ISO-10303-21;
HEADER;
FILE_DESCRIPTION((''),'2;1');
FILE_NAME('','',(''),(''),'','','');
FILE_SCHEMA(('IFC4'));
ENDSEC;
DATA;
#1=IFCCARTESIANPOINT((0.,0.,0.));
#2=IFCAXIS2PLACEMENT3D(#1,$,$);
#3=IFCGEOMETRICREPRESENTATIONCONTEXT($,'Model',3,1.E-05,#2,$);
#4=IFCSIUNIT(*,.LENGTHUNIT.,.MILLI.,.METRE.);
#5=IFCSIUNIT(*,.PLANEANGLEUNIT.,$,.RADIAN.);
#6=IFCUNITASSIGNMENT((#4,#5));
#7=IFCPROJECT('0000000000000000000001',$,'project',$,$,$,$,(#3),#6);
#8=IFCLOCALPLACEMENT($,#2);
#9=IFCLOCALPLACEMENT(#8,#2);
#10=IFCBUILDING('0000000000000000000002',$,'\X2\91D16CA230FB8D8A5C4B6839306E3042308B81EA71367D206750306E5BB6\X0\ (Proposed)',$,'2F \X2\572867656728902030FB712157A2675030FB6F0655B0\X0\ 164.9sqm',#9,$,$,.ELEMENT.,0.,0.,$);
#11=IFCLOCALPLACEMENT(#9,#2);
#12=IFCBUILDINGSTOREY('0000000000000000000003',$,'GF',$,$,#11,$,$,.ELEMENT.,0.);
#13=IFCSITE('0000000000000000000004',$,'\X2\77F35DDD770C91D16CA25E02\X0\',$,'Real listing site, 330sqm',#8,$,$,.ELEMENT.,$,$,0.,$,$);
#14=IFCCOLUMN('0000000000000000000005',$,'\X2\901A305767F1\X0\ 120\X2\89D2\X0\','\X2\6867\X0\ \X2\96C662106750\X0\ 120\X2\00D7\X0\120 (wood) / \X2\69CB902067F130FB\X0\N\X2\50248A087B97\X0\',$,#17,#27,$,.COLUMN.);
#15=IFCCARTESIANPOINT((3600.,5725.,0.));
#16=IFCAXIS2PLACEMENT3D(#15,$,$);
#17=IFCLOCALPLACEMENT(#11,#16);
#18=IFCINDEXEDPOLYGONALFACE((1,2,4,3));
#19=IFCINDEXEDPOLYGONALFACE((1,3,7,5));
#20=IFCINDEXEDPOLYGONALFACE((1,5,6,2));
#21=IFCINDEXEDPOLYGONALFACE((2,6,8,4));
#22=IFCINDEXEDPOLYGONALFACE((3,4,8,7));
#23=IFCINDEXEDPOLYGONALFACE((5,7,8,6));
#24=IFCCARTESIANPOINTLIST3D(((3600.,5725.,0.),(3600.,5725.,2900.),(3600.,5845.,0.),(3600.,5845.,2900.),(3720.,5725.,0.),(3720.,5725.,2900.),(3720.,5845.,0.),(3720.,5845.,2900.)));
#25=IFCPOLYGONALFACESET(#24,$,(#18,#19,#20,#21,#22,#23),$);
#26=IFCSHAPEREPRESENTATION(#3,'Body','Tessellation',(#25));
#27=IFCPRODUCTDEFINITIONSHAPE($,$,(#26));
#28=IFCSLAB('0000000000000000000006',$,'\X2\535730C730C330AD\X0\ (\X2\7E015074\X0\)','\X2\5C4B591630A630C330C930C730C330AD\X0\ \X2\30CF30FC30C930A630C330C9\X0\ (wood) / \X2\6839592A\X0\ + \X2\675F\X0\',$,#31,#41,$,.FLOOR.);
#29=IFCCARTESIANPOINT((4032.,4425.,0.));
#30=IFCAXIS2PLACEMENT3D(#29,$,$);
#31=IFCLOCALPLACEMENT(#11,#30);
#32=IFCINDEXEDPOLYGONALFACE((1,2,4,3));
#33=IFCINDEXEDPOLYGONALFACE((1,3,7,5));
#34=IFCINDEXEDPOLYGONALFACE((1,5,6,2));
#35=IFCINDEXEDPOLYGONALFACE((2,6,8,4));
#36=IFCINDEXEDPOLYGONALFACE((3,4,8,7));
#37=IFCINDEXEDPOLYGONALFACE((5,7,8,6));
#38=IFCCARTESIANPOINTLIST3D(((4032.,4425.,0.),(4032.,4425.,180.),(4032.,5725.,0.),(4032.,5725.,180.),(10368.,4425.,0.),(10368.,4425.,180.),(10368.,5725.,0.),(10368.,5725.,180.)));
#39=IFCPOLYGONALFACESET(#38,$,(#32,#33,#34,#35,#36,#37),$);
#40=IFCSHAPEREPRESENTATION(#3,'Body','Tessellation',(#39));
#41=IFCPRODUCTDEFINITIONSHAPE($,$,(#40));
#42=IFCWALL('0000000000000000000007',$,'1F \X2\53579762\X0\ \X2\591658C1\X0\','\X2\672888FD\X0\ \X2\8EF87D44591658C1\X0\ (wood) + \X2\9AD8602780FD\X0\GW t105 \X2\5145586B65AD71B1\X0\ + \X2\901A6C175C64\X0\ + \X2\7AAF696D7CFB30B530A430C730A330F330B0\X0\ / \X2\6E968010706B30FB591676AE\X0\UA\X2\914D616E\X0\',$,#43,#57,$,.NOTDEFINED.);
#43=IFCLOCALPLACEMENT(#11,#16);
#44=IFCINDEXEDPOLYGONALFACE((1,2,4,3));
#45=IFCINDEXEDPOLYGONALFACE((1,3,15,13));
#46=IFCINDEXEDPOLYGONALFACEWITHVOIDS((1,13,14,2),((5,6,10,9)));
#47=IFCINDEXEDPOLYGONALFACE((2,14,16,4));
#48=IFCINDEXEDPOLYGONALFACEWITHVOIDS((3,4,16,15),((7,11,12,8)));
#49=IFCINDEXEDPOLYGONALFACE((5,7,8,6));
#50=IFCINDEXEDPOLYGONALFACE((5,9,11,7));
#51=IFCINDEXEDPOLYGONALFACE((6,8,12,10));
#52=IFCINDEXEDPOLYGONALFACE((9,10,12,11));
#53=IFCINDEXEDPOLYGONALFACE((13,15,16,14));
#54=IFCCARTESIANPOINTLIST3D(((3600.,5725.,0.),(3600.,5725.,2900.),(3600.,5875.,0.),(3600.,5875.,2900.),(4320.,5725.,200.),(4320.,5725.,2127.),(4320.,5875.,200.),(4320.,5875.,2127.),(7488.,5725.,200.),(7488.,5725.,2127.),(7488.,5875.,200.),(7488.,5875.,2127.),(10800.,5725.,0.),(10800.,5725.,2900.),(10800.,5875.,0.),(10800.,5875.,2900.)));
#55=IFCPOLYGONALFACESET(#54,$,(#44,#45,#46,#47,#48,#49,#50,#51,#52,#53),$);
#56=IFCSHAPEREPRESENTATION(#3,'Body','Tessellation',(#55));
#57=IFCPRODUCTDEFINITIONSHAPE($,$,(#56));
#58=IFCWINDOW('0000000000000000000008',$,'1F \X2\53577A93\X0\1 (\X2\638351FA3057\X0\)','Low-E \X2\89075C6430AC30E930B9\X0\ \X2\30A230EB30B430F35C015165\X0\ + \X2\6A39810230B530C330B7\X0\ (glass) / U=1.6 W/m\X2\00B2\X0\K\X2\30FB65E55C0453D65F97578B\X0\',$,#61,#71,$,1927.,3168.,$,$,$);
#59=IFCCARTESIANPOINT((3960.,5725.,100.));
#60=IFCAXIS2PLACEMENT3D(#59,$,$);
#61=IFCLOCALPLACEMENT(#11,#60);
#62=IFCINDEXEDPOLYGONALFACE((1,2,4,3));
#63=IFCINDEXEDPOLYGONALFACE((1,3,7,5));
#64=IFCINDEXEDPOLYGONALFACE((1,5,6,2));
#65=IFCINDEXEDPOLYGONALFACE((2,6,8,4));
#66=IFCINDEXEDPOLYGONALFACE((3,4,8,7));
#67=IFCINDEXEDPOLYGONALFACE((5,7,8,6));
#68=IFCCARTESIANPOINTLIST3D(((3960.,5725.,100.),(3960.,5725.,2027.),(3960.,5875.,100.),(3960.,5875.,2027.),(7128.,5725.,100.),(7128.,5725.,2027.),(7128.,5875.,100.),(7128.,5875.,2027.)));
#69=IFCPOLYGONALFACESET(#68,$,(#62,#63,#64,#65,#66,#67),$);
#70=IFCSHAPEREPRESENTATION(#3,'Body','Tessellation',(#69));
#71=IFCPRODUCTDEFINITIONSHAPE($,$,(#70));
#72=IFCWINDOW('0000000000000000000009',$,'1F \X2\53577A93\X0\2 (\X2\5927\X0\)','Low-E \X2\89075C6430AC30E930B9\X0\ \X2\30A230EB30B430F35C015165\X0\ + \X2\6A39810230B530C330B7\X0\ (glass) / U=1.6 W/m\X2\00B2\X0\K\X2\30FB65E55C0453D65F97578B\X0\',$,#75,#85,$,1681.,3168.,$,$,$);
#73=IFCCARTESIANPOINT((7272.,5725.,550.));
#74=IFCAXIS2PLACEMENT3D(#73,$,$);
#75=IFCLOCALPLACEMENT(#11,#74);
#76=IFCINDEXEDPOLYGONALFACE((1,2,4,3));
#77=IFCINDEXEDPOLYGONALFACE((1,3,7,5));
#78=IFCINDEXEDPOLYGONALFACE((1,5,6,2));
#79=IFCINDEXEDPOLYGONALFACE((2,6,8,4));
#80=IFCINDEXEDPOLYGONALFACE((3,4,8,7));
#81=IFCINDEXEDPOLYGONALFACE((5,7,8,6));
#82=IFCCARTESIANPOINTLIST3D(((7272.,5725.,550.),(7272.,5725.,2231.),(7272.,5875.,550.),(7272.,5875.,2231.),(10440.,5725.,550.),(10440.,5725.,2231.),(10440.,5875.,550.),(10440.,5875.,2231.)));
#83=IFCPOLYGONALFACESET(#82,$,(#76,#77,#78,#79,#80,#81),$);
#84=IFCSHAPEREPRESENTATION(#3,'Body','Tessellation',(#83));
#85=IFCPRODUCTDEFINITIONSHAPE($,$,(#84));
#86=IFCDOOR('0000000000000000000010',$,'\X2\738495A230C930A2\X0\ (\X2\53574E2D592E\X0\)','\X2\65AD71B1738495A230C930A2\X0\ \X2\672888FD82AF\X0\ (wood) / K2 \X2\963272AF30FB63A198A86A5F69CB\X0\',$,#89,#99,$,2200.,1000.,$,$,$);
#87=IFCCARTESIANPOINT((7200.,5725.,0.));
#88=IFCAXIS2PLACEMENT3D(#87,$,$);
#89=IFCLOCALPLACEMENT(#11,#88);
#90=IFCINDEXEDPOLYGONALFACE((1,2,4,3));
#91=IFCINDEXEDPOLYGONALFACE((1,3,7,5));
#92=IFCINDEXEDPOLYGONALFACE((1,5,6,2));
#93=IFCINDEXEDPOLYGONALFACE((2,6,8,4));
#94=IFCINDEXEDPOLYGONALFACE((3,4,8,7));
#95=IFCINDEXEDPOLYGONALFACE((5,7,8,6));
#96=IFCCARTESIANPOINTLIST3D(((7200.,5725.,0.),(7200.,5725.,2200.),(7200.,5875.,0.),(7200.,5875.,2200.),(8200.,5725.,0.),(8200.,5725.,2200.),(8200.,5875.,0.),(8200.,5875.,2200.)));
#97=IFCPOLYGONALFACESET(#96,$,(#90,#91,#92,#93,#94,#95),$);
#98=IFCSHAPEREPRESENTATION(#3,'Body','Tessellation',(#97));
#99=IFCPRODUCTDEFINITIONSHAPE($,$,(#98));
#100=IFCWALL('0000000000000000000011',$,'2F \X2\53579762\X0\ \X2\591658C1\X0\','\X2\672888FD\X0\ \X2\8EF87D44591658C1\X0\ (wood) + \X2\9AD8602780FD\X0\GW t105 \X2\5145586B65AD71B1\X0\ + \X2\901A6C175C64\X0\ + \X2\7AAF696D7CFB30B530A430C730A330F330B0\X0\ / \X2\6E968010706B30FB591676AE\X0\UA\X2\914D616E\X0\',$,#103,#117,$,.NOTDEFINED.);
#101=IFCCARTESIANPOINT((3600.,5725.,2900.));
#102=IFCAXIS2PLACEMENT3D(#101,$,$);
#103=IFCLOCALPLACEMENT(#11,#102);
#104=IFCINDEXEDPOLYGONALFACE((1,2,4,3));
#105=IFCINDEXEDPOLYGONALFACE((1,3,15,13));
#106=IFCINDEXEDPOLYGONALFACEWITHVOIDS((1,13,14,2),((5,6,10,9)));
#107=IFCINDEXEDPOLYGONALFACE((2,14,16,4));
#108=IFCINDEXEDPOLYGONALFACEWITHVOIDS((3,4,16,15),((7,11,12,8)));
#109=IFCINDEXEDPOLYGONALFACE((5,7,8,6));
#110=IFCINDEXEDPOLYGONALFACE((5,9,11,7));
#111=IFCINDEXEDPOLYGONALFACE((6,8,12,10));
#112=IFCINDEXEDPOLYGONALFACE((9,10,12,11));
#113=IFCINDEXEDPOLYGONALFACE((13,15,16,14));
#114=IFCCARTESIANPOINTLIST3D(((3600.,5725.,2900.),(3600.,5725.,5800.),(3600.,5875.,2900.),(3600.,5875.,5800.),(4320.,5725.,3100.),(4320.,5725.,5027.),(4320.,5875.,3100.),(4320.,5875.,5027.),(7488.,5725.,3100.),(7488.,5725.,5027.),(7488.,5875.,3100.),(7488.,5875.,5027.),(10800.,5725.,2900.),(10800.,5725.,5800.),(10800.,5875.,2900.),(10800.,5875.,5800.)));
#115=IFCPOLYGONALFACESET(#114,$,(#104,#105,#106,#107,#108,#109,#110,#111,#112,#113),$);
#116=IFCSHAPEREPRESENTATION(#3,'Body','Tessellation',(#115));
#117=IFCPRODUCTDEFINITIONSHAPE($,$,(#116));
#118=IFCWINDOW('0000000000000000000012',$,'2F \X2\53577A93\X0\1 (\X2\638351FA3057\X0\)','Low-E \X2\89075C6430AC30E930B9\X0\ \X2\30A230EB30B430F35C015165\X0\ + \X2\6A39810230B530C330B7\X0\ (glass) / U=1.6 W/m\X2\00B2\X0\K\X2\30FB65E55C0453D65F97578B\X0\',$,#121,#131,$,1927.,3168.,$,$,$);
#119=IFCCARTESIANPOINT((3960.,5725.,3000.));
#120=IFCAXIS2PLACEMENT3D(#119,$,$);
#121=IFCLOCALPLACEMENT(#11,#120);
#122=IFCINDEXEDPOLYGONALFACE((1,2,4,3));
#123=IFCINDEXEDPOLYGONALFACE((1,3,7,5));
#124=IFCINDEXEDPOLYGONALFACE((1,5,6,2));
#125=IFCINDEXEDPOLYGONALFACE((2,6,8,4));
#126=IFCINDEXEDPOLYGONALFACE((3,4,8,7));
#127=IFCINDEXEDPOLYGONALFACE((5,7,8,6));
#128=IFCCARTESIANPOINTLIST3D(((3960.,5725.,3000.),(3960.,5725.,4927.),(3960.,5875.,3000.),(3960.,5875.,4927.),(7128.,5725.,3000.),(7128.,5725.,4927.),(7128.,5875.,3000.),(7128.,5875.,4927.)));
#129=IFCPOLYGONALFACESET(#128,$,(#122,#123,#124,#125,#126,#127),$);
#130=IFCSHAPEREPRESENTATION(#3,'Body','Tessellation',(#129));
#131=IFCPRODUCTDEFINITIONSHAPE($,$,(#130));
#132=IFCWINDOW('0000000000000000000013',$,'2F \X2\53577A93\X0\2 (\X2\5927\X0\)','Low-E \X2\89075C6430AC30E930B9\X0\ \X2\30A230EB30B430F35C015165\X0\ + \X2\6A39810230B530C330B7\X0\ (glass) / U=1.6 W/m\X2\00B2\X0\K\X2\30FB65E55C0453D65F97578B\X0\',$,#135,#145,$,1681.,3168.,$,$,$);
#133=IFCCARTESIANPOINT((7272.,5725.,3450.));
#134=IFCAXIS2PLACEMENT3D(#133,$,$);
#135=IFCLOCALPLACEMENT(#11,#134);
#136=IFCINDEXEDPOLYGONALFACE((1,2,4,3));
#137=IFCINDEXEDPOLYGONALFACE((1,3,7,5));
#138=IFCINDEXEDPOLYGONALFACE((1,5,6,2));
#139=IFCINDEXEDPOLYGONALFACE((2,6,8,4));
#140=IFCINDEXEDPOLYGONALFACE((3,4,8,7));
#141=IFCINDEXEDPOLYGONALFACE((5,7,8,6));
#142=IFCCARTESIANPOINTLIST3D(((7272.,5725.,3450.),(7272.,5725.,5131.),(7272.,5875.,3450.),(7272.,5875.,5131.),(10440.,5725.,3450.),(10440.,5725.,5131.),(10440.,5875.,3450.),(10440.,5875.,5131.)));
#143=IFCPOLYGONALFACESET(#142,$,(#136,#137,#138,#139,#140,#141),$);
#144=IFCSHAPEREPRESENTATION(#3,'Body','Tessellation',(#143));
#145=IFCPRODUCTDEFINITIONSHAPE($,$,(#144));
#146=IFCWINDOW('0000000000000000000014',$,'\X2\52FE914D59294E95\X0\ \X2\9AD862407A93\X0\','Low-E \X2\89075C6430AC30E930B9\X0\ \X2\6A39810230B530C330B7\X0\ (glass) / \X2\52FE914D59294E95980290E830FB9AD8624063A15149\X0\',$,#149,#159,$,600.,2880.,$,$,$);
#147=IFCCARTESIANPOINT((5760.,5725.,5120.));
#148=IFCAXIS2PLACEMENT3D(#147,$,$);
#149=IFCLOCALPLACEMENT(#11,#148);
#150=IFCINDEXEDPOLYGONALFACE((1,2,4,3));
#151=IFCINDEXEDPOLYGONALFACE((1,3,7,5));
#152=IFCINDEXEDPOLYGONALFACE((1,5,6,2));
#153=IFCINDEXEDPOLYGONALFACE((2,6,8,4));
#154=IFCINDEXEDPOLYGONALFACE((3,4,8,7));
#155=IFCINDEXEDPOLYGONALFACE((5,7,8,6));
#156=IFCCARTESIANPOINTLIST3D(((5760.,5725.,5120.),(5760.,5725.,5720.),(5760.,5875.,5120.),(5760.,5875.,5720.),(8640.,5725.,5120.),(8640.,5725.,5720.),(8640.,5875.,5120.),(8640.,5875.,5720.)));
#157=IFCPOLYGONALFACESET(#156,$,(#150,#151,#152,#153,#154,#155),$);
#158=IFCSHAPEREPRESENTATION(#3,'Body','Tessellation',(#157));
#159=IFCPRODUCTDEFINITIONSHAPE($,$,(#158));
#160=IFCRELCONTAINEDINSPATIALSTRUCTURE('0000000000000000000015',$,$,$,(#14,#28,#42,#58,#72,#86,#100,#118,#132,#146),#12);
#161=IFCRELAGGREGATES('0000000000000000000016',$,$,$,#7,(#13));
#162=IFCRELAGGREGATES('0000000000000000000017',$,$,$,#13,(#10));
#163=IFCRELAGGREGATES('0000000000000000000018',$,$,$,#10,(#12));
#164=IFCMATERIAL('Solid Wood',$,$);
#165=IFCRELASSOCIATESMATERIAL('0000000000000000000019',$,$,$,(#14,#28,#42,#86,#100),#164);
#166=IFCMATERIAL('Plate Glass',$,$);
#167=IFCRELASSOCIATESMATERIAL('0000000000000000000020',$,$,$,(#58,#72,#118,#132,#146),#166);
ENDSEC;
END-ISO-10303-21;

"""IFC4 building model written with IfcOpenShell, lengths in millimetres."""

from ifc_helpers import new_model, si_unit, frame, frame_2d, origin, place, context, project, spatial, rectangle, extrude, material, element, fill, save


model = new_model("IFC4")

# Units and contexts
model_context = context("Model", 3, precision=1e-05, world=origin())
ifc_project = project(units=[si_unit("LENGTHUNIT", "METRE", prefix="MILLI"), si_unit("PLANEANGLEUNIT", "RADIAN")], contexts=[model_context])

# Site, building, storey
site_placement = place(None, origin())
site = spatial("IfcSite", under=ifc_project, at=site_placement, Name="石川県金沢市", ObjectType="Real listing site, 330sqm", CompositionType="ELEMENT", RefElevation=0.0)
building_placement = place(site_placement, origin())
building = spatial("IfcBuilding", under=site, at=building_placement, Name="金沢・越屋根のある自然素材の家 (Proposed)", ObjectType="2F 在来木造・無垢材・漆喰 164.9sqm", CompositionType="ELEMENT", ElevationOfRefHeight=0.0, ElevationOfTerrain=0.0)
storey_placement = place(building_placement, origin())
storey = spatial("IfcBuildingStorey", under=building, at=storey_placement, Name="GF", CompositionType="ELEMENT", Elevation=0.0)

# Column
ifc_material_1 = material(Name="Solid Wood")
column_placement = place(storey_placement, frame((3600.0, 5725.0, 0.0)))
element("IfcColumn", 1, at=column_placement, inside=storey, material=ifc_material_1, Name="通し柱 120角", Description="桧 集成材 120×120 (wood) / 構造柱・N値計算", PredefinedType="COLUMN", context=model_context, shape_type="SweptSolid", body=[
    extrude(rectangle(XDim=120.0, YDim=120.0, at=frame_2d((60.0, 60.0))), frame((3600.0, 5725.0, 0.0)), (0.0, 0.0, 1.0), 2900.0),
])

# Slab
slab_1_placement = place(storey_placement, frame((4032.0, 4425.0, 0.0)))
element("IfcSlab", 2, at=slab_1_placement, inside=storey, material=ifc_material_1, Name="南デッキ (縁側)", Description="屋外ウッドデッキ ハードウッド (wood) / 根太 + 束", PredefinedType="FLOOR", context=model_context, shape_type="SweptSolid", body=[
    extrude(rectangle(XDim=6336.0, YDim=1300.0, at=frame_2d((3168.0, 650.0))), frame((4032.0, 4425.0, 0.0)), (0.0, 0.0, 1.0), 180.0),
])

# Wall, openings, windows, door
wall_1_placement = place(storey_placement, frame((3600.0, 5725.0, 0.0)))
wall_1 = element("IfcWall", 3, at=wall_1_placement, inside=storey, material=ifc_material_1, Name="1F 南面 外壁", Description="木製 軸組外壁 (wood) + 高性能GW t105 充填断熱 + 通気層 + 窯業系サイディング / 準耐火・外皮UA配慮", PredefinedType="NOTDEFINED", context=model_context, shape_type="SweptSolid", body=[
    extrude(rectangle(XDim=7200.0, YDim=150.0, at=frame_2d((3600.0, 75.0))), frame((3600.0, 5725.0, 0.0)), (0.0, 0.0, 1.0), 2900.0),
])
opening_1_placement = place(storey_placement, frame((3960.0, 5725.0, 100.0)))
opening_1 = element("IfcOpeningElement", 4, at=opening_1_placement, cuts=wall_1, PredefinedType="NOTDEFINED", context=model_context, shape_type="SweptSolid", body=[
    extrude(rectangle(XDim=3168.0, YDim=150.0, at=frame_2d((1584.0, 75.0))), frame((3960.0, 5725.0, 100.0)), (0.0, 0.0, 1.0), 1927.0),
])
opening_2_placement = place(storey_placement, frame((7272.0, 5725.0, 550.0)))
opening_2 = element("IfcOpeningElement", 5, at=opening_2_placement, cuts=wall_1, PredefinedType="NOTDEFINED", context=model_context, shape_type="SweptSolid", body=[
    extrude(rectangle(XDim=3168.0, YDim=150.0, at=frame_2d((1584.0, 75.0))), frame((7272.0, 5725.0, 550.0)), (0.0, 0.0, 1.0), 1681.0),
])
opening_3_placement = place(storey_placement, frame((7200.0, 5725.0, 0.0)))
opening_3 = element("IfcOpeningElement", 6, at=opening_3_placement, cuts=wall_1, PredefinedType="NOTDEFINED", context=model_context, shape_type="SweptSolid", body=[
    extrude(rectangle(XDim=1000.0, YDim=150.0, at=frame_2d((500.0, 75.0))), frame((7200.0, 5725.0, 0.0)), (0.0, 0.0, 1.0), 2200.0),
])
ifc_material_2 = material(Name="Plate Glass")
window_1_placement = place(storey_placement, frame((3960.0, 5725.0, 100.0)))
window_1 = element("IfcWindow", 7, at=window_1_placement, inside=storey, material=ifc_material_2, Name="1F 南窓1 (掃出し)", Description="Low-E 複層ガラス アルゴン封入 + 樹脂サッシ (glass) / U=1.6 W/m²K・日射取得型", OverallHeight=1927.0, OverallWidth=3168.0, context=model_context, shape_type="SweptSolid", body=[
    extrude(rectangle(XDim=3168.0, YDim=150.0, at=frame_2d((1584.0, 75.0))), frame((3960.0, 5725.0, 100.0)), (0.0, 0.0, 1.0), 1927.0),
])
fill(opening_1, window_1)
window_2_placement = place(storey_placement, frame((7272.0, 5725.0, 550.0)))
window_2 = element("IfcWindow", 8, at=window_2_placement, inside=storey, material=ifc_material_2, Name="1F 南窓2 (大)", Description="Low-E 複層ガラス アルゴン封入 + 樹脂サッシ (glass) / U=1.6 W/m²K・日射取得型", OverallHeight=1681.0, OverallWidth=3168.0, context=model_context, shape_type="SweptSolid", body=[
    extrude(rectangle(XDim=3168.0, YDim=150.0, at=frame_2d((1584.0, 75.0))), frame((7272.0, 5725.0, 550.0)), (0.0, 0.0, 1.0), 1681.0),
])
fill(opening_2, window_2)
door_placement = place(storey_placement, frame((7200.0, 5725.0, 0.0)))
door = element("IfcDoor", 9, at=door_placement, inside=storey, material=ifc_material_1, Name="玄関ドア (南中央)", Description="断熱玄関ドア 木製芯 (wood) / K2 防犯・採風機構", OverallHeight=2200.0, OverallWidth=1000.0, context=model_context, shape_type="SweptSolid", body=[
    extrude(rectangle(XDim=1000.0, YDim=150.0, at=frame_2d((500.0, 75.0))), frame((7200.0, 5725.0, 0.0)), (0.0, 0.0, 1.0), 2200.0),
])
fill(opening_3, door)

# Wall, openings, windows
wall_2_placement = place(storey_placement, frame((3600.0, 5725.0, 2900.0)))
wall_2 = element("IfcWall", 10, at=wall_2_placement, inside=storey, material=ifc_material_1, Name="2F 南面 外壁", Description="木製 軸組外壁 (wood) + 高性能GW t105 充填断熱 + 通気層 + 窯業系サイディング / 準耐火・外皮UA配慮", PredefinedType="NOTDEFINED", context=model_context, shape_type="SweptSolid", body=[
    extrude(rectangle(XDim=7200.0, YDim=150.0, at=frame_2d((3600.0, 75.0))), frame((3600.0, 5725.0, 2900.0)), (0.0, 0.0, 1.0), 2900.0),
])
opening_4_placement = place(storey_placement, frame((3960.0, 5725.0, 3000.0)))
opening_4 = element("IfcOpeningElement", 11, at=opening_4_placement, cuts=wall_2, PredefinedType="NOTDEFINED", context=model_context, shape_type="SweptSolid", body=[
    extrude(rectangle(XDim=3168.0, YDim=150.0, at=frame_2d((1584.0, 75.0))), frame((3960.0, 5725.0, 3000.0)), (0.0, 0.0, 1.0), 1927.0),
])
opening_5_placement = place(storey_placement, frame((7272.0, 5725.0, 3450.0)))
opening_5 = element("IfcOpeningElement", 12, at=opening_5_placement, cuts=wall_2, PredefinedType="NOTDEFINED", context=model_context, shape_type="SweptSolid", body=[
    extrude(rectangle(XDim=3168.0, YDim=150.0, at=frame_2d((1584.0, 75.0))), frame((7272.0, 5725.0, 3450.0)), (0.0, 0.0, 1.0), 1681.0),
])
opening_6_placement = place(storey_placement, frame((5760.0, 5725.0, 5120.0)))
opening_6 = element("IfcOpeningElement", 13, at=opening_6_placement, cuts=wall_2, PredefinedType="NOTDEFINED", context=model_context, shape_type="SweptSolid", body=[
    extrude(rectangle(XDim=2880.0, YDim=150.0, at=frame_2d((1440.0, 75.0))), frame((5760.0, 5725.0, 5120.0)), (0.0, 0.0, 1.0), 600.0),
])
window_3_placement = place(storey_placement, frame((3960.0, 5725.0, 3000.0)))
window_3 = element("IfcWindow", 14, at=window_3_placement, inside=storey, material=ifc_material_2, Name="2F 南窓1 (掃出し)", Description="Low-E 複層ガラス アルゴン封入 + 樹脂サッシ (glass) / U=1.6 W/m²K・日射取得型", OverallHeight=1927.0, OverallWidth=3168.0, context=model_context, shape_type="SweptSolid", body=[
    extrude(rectangle(XDim=3168.0, YDim=150.0, at=frame_2d((1584.0, 75.0))), frame((3960.0, 5725.0, 3000.0)), (0.0, 0.0, 1.0), 1927.0),
])
fill(opening_4, window_3)
window_4_placement = place(storey_placement, frame((7272.0, 5725.0, 3450.0)))
window_4 = element("IfcWindow", 15, at=window_4_placement, inside=storey, material=ifc_material_2, Name="2F 南窓2 (大)", Description="Low-E 複層ガラス アルゴン封入 + 樹脂サッシ (glass) / U=1.6 W/m²K・日射取得型", OverallHeight=1681.0, OverallWidth=3168.0, context=model_context, shape_type="SweptSolid", body=[
    extrude(rectangle(XDim=3168.0, YDim=150.0, at=frame_2d((1584.0, 75.0))), frame((7272.0, 5725.0, 3450.0)), (0.0, 0.0, 1.0), 1681.0),
])
fill(opening_5, window_4)
window_5_placement = place(storey_placement, frame((5760.0, 5725.0, 5120.0)))
window_5 = element("IfcWindow", 16, at=window_5_placement, inside=storey, material=ifc_material_2, Name="勾配天井 高所窓", Description="Low-E 複層ガラス 樹脂サッシ (glass) / 勾配天井頂部・高所採光", OverallHeight=600.0, OverallWidth=2880.0, context=model_context, shape_type="SweptSolid", body=[
    extrude(rectangle(XDim=2880.0, YDim=150.0, at=frame_2d((1440.0, 75.0))), frame((5760.0, 5725.0, 5120.0)), (0.0, 0.0, 1.0), 600.0),
])
fill(opening_6, window_5)

save(model, "model.ifc")
